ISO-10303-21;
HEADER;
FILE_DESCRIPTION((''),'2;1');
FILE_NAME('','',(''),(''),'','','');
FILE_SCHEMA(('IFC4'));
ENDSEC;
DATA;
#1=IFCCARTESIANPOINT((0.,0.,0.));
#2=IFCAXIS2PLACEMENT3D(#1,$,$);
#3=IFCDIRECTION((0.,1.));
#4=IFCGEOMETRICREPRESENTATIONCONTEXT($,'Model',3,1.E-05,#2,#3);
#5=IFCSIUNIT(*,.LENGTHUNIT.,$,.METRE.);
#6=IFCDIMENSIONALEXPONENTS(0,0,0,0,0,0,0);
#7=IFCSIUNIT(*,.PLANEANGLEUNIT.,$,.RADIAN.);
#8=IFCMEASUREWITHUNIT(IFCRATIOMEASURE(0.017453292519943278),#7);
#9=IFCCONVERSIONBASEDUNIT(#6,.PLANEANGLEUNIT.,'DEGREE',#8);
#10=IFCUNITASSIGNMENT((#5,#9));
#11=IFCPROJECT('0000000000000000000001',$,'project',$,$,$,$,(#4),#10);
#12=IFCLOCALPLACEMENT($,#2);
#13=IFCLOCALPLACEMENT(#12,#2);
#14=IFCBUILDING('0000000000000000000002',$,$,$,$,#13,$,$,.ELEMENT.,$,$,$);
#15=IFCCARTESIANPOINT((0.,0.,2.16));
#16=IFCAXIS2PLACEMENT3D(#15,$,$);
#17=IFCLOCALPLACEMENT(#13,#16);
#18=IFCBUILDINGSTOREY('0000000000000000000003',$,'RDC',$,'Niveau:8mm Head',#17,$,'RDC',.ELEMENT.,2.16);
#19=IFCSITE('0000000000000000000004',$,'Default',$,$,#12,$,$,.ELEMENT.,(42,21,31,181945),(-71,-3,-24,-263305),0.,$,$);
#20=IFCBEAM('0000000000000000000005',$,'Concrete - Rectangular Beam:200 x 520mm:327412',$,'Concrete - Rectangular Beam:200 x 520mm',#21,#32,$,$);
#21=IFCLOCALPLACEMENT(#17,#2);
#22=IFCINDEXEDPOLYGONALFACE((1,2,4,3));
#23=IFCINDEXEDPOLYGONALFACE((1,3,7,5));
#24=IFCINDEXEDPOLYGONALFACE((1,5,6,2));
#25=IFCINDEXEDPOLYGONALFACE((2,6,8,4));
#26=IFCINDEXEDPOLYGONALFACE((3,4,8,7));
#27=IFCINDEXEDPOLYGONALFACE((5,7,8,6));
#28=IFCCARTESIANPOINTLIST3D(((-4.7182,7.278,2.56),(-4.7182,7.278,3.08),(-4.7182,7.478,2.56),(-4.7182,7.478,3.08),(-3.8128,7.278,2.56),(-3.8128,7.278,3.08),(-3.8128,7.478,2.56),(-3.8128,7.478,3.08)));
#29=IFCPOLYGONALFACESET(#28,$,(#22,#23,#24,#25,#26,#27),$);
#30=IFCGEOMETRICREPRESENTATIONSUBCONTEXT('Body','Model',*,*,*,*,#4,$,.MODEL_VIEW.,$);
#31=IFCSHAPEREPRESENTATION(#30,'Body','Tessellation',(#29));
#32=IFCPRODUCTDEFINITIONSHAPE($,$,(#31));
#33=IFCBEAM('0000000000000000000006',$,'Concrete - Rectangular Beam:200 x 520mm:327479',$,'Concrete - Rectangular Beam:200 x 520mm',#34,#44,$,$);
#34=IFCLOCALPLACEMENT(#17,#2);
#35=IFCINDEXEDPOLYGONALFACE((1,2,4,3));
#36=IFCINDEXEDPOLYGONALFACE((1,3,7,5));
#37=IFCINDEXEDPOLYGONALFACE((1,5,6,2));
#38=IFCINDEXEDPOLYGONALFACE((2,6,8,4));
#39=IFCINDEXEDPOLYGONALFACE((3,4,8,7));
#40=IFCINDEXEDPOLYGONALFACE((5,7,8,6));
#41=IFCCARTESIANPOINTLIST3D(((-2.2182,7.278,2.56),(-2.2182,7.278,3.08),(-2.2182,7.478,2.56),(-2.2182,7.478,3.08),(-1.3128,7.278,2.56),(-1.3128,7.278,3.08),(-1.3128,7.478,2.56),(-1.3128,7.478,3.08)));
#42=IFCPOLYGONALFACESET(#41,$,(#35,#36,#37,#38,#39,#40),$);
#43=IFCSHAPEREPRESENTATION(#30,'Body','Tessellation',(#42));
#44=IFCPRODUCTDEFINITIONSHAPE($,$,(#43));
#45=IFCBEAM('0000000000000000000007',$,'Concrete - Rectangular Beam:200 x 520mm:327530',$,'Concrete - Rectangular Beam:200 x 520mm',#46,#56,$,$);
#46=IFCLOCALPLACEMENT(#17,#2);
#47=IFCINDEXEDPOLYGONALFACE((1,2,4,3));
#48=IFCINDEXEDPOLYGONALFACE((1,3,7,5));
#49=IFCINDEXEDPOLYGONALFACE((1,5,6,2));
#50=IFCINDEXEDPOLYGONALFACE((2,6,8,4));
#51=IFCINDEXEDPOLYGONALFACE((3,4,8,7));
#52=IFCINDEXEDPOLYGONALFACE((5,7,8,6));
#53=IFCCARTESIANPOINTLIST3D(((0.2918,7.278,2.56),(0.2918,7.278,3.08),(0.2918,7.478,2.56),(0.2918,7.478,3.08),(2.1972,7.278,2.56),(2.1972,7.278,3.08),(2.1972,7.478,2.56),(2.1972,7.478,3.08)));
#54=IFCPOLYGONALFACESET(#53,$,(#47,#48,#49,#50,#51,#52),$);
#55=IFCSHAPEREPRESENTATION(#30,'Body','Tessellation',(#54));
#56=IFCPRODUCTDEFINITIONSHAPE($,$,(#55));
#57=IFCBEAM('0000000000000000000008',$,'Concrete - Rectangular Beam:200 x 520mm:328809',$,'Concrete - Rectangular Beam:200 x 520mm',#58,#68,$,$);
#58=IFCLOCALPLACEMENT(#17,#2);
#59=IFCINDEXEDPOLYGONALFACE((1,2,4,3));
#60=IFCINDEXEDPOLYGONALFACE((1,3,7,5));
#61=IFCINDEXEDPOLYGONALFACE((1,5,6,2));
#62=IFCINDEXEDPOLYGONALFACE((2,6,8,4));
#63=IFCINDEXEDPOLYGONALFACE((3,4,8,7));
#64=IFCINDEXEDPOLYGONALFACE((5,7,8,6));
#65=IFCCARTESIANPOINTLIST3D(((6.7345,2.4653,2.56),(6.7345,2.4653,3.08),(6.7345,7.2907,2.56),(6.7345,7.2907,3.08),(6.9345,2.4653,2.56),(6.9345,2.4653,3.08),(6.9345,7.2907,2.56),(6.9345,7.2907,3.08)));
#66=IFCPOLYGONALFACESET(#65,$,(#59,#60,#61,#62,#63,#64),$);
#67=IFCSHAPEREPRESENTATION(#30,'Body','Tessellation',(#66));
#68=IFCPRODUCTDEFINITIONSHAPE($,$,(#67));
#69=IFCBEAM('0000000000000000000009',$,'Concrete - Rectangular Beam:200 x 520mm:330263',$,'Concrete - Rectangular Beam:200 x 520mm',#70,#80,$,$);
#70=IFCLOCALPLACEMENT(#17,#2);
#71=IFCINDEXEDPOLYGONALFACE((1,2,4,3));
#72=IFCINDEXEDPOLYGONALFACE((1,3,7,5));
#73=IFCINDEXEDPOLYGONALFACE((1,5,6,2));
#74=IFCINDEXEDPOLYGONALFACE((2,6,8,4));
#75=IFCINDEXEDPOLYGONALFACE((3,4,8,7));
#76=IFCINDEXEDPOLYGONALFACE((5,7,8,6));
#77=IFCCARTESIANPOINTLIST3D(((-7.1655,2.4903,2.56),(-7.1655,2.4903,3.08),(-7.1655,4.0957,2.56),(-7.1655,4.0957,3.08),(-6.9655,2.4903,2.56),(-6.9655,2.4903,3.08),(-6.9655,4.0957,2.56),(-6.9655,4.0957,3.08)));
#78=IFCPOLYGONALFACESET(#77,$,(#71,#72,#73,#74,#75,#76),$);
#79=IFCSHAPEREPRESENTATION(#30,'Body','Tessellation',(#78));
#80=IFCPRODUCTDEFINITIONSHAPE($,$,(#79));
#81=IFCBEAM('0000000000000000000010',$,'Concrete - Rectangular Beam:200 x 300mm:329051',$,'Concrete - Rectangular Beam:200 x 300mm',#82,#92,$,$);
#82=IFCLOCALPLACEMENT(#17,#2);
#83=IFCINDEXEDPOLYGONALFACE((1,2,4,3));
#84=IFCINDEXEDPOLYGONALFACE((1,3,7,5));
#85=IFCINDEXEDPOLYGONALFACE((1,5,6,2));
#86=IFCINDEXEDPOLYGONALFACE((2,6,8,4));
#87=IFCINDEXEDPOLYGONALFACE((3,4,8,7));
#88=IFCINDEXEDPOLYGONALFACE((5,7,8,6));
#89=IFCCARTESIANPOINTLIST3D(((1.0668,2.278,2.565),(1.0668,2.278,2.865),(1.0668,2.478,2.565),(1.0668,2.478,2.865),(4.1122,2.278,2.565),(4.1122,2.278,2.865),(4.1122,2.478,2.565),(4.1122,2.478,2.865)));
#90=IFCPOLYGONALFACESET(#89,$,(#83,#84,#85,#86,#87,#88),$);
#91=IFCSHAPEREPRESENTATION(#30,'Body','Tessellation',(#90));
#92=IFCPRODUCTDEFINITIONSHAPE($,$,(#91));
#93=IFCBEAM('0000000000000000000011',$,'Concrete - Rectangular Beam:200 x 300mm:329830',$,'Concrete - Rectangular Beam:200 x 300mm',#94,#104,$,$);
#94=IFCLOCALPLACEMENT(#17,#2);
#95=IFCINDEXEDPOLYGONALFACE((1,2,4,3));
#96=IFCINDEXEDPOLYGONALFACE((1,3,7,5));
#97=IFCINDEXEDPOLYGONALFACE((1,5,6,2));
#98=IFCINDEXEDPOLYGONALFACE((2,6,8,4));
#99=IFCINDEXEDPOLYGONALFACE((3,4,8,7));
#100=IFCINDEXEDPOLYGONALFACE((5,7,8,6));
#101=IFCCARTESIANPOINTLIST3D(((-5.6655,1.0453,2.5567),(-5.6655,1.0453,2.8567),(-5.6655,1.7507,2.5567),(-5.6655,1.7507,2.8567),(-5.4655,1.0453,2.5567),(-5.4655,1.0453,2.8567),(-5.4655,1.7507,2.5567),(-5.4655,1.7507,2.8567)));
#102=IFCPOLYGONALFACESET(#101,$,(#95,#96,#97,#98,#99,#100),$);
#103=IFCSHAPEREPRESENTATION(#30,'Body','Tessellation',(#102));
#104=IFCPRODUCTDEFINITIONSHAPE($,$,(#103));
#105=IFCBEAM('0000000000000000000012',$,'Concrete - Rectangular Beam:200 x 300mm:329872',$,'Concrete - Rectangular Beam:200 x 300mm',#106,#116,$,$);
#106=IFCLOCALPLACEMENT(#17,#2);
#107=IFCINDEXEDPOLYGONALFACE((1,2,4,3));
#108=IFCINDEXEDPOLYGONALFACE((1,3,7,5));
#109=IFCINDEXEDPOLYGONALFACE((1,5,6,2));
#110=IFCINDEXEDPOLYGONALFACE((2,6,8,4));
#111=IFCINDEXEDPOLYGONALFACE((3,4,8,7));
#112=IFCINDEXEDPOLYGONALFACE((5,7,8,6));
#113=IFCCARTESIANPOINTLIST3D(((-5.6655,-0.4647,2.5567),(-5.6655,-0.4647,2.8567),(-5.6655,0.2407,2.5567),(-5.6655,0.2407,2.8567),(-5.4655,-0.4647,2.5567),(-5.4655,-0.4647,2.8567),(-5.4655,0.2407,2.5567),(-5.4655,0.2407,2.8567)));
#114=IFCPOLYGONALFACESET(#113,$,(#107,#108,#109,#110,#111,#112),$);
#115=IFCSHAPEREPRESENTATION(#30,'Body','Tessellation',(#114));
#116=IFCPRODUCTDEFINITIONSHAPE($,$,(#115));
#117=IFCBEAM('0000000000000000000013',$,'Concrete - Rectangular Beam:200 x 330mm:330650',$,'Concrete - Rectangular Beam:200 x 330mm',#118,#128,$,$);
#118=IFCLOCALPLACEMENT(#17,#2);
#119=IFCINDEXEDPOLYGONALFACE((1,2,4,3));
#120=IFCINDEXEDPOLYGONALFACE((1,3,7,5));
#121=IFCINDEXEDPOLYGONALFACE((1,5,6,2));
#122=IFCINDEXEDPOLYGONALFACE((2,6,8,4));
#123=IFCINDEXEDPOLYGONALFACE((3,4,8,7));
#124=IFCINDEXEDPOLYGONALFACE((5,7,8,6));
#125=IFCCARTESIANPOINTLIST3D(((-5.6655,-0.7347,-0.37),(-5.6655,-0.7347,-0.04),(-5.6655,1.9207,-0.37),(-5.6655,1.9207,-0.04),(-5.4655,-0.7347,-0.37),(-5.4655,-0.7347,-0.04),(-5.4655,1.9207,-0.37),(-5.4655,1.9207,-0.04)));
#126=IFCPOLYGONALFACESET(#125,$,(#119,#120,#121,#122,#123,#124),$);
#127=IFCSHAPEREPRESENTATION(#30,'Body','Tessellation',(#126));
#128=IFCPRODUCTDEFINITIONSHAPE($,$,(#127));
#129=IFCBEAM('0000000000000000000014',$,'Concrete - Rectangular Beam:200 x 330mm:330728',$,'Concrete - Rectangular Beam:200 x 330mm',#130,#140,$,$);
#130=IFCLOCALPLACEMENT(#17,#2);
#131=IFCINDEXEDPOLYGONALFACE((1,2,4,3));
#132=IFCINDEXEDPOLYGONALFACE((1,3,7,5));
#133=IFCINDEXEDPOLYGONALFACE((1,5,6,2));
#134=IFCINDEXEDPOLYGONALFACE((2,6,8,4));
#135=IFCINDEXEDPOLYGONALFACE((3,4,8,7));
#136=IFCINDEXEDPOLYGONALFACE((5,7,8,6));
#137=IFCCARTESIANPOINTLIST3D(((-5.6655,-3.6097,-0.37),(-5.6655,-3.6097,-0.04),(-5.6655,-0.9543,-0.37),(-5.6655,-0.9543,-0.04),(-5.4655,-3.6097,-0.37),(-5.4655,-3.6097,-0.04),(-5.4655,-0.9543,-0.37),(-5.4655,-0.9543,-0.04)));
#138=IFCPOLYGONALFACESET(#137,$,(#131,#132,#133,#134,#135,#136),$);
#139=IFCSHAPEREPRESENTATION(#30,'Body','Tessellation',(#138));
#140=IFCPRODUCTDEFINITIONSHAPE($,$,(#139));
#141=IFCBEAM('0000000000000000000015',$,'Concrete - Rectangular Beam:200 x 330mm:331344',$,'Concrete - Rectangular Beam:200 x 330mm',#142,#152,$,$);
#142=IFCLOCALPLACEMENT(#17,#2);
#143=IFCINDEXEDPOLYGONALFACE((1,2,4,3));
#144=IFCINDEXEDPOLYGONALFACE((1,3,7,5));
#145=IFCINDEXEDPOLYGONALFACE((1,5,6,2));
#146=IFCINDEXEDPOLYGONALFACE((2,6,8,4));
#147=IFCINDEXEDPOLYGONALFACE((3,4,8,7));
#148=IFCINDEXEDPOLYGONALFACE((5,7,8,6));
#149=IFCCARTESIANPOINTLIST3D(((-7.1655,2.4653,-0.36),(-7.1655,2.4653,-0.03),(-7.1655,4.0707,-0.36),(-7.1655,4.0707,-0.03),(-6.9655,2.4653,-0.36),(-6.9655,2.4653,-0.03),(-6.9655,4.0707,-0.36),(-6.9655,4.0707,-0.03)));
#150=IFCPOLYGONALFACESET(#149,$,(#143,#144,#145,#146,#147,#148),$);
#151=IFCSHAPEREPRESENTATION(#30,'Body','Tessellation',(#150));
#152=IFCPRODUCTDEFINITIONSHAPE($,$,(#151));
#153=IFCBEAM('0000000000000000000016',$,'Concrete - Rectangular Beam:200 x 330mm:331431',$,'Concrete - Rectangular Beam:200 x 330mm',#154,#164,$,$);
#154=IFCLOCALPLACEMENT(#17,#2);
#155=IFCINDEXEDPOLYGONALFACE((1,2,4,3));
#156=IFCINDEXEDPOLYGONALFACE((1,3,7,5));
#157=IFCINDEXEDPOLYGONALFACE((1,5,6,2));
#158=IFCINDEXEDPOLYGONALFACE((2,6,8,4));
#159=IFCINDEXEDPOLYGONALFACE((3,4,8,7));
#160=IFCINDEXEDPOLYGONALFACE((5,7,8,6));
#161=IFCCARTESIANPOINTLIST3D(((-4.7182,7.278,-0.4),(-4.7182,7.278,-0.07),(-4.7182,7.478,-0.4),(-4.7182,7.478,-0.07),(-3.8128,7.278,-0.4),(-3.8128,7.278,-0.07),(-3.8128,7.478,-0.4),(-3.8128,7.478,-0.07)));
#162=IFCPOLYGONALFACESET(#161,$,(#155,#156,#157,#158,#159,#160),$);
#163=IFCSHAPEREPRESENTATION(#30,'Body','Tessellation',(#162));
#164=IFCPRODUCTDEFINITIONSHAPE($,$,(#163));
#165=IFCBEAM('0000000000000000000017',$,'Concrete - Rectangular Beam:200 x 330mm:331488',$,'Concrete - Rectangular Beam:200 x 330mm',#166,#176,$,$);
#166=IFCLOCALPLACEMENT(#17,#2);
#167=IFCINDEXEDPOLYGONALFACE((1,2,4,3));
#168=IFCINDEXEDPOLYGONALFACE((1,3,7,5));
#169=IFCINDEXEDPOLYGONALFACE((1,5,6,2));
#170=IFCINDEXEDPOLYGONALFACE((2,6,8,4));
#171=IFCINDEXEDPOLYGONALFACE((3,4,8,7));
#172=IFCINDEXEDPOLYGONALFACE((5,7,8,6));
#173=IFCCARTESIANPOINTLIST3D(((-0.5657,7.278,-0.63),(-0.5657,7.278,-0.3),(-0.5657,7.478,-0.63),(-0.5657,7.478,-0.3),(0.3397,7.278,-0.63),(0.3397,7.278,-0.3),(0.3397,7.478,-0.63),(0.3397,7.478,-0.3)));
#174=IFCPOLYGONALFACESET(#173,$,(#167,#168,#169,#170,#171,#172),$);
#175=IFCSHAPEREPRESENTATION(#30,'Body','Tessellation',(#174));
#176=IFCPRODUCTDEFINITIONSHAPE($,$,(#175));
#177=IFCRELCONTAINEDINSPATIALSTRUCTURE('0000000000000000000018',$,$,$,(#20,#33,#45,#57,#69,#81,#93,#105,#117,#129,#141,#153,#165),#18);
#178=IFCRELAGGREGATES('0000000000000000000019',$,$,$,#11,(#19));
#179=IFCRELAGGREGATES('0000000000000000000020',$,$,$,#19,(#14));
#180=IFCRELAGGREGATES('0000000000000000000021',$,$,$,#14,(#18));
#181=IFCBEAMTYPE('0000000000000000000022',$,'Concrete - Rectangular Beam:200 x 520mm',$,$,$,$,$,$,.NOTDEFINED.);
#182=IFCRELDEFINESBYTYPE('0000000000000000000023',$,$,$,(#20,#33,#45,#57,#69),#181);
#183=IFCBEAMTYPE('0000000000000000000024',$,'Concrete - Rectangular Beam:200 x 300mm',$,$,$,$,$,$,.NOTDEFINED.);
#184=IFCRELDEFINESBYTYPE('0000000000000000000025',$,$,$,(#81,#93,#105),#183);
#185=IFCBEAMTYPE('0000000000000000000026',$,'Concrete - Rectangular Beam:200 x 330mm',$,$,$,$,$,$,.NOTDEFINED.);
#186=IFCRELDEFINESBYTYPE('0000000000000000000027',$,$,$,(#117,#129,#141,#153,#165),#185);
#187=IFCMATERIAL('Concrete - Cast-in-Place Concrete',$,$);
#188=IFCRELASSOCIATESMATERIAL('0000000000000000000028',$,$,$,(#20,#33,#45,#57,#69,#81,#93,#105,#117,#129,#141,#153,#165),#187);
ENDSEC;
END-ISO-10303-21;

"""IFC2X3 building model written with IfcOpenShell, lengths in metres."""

from ifc_helpers import new_model, entity, si_unit, converted_unit, direction, frame, frame_2d, origin, place, context, subcontext, project, spatial, rectangle, extrude, material, type_object, element, save


model = new_model("IFC2X3")

# Units and contexts
model_context = context("Model", 3, precision=1e-05, world=origin(), true_north=direction((0.0, 1.0)))
body_context = subcontext(model_context, "Body", "Model", "MODEL_VIEW")
ifc_project = project(units=[si_unit("LENGTHUNIT", "METRE"), converted_unit("PLANEANGLEUNIT", "DEGREE", entity("IfcRatioMeasure", 0.017453292519943278), si_unit("PLANEANGLEUNIT", "RADIAN"), dimensions=[0, 0, 0, 0, 0, 0, 0])], contexts=[model_context])

# Site, building, storey
site_placement = place(None, origin())
site = spatial("IfcSite", under=ifc_project, at=site_placement, Name="Default", CompositionType="ELEMENT", RefLatitude=(42, 21, 31, 181945), RefLongitude=(-71, -3, -24, -263305), RefElevation=0.0)
building_placement = place(site_placement, origin())
building = spatial("IfcBuilding", under=site, at=building_placement, CompositionType="ELEMENT")
storey_placement = place(building_placement, frame((0.0, 0.0, 2.16)))
storey = spatial("IfcBuildingStorey", under=building, at=storey_placement, Name="RDC", ObjectType="Niveau:8mm Head", LongName="RDC", CompositionType="ELEMENT", Elevation=2.16)

# Beams
ifc_material_1 = material(Name="Concrete - Cast-in-Place Concrete")
beam_type_1 = type_object("IfcBeamType", Name="Concrete - Rectangular Beam:200 x 520mm", PredefinedType="NOTDEFINED")
beam_1_placement = place(storey_placement, frame((-4.7055, 7.378, 3.08)))
element("IfcBeam", 1, at=beam_1_placement, inside=storey, type_object=beam_type_1, material=ifc_material_1, Name="Concrete - Rectangular Beam:200 x 520mm:327412", ObjectType="Concrete - Rectangular Beam:200 x 520mm", context=body_context, shape_type="SweptSolid", body=[
    extrude(rectangle(XDim=0.52, YDim=0.2, at=frame_2d((0.0, 0.0), x_axis=(1.0, 0.0))), frame((-0.0127, 0.0, -0.26), z_axis=(1.0, 0.0, 0.0), x_axis=(0.0, 0.0, -1.0)), (0.0, 0.0, 1.0), 0.9054),
])
beam_2_placement = place(storey_placement, frame((-2.2055, 7.378, 3.08)))
element("IfcBeam", 2, at=beam_2_placement, inside=storey, type_object=beam_type_1, material=ifc_material_1, Name="Concrete - Rectangular Beam:200 x 520mm:327479", ObjectType="Concrete - Rectangular Beam:200 x 520mm", context=body_context, shape_type="SweptSolid", body=[
    extrude(rectangle(XDim=0.52, YDim=0.2, at=frame_2d((0.0, 0.0), x_axis=(1.0, 0.0))), frame((-0.0127, 0.0, -0.26), z_axis=(1.0, 0.0, 0.0), x_axis=(0.0, 0.0, -1.0)), (0.0, 0.0, 1.0), 0.9054),
])
beam_3_placement = place(storey_placement, frame((0.3045, 7.378, 3.08)))
element("IfcBeam", 3, at=beam_3_placement, inside=storey, type_object=beam_type_1, material=ifc_material_1, Name="Concrete - Rectangular Beam:200 x 520mm:327530", ObjectType="Concrete - Rectangular Beam:200 x 520mm", context=body_context, shape_type="SweptSolid", body=[
    extrude(rectangle(XDim=0.52, YDim=0.2, at=frame_2d((0.0, 0.0), x_axis=(1.0, 0.0))), frame((-0.0127, 0.0, -0.26), z_axis=(1.0, 0.0, 0.0), x_axis=(0.0, 0.0, -1.0)), (0.0, 0.0, 1.0), 1.9054),
])
beam_4_placement = place(storey_placement, frame((6.8345, 7.278, 3.08), z_axis=(0.0, 0.0, 1.0), x_axis=(0.0, -1.0, 0.0)))
element("IfcBeam", 4, at=beam_4_placement, inside=storey, type_object=beam_type_1, material=ifc_material_1, Name="Concrete - Rectangular Beam:200 x 520mm:328809", ObjectType="Concrete - Rectangular Beam:200 x 520mm", context=body_context, shape_type="SweptSolid", body=[
    extrude(rectangle(XDim=0.52, YDim=0.2, at=frame_2d((0.0, 0.0), x_axis=(1.0, 0.0))), frame((-0.0127, 0.0, -0.26), z_axis=(1.0, 0.0, 0.0), x_axis=(0.0, 0.0, -1.0)), (0.0, 0.0, 1.0), 4.8254),
])
beam_5_placement = place(storey_placement, frame((-7.0655, 2.503, 3.08), z_axis=(0.0, 0.0, 1.0), x_axis=(0.0, 1.0, 0.0)))
element("IfcBeam", 5, at=beam_5_placement, inside=storey, type_object=beam_type_1, material=ifc_material_1, Name="Concrete - Rectangular Beam:200 x 520mm:330263", ObjectType="Concrete - Rectangular Beam:200 x 520mm", context=body_context, shape_type="SweptSolid", body=[
    extrude(rectangle(XDim=0.52, YDim=0.2, at=frame_2d((0.0, 0.0), x_axis=(1.0, 0.0))), frame((-0.0127, 0.0, -0.26), z_axis=(1.0, 0.0, 0.0), x_axis=(0.0, 0.0, -1.0)), (0.0, 0.0, 1.0), 1.6054),
])
beam_type_2 = type_object("IfcBeamType", Name="Concrete - Rectangular Beam:200 x 300mm", PredefinedType="NOTDEFINED")
beam_6_placement = place(storey_placement, frame((1.0795, 2.378, 2.865)))
element("IfcBeam", 6, at=beam_6_placement, inside=storey, type_object=beam_type_2, material=ifc_material_1, Name="Concrete - Rectangular Beam:200 x 300mm:329051", ObjectType="Concrete - Rectangular Beam:200 x 300mm", context=body_context, shape_type="SweptSolid", body=[
    extrude(rectangle(XDim=0.3, YDim=0.2, at=frame_2d((0.0, 0.0), x_axis=(1.0, 0.0))), frame((-0.0127, 0.0, -0.15), z_axis=(1.0, 0.0, 0.0), x_axis=(0.0, 0.0, -1.0)), (0.0, 0.0, 1.0), 3.0454),
])
beam_7_placement = place(storey_placement, frame((-5.5655, 1.738, 2.8567), z_axis=(0.0, 0.0, 1.0), x_axis=(0.0, -1.0, 0.0)))
element("IfcBeam", 7, at=beam_7_placement, inside=storey, type_object=beam_type_2, material=ifc_material_1, Name="Concrete - Rectangular Beam:200 x 300mm:329830", ObjectType="Concrete - Rectangular Beam:200 x 300mm", context=body_context, shape_type="SweptSolid", body=[
    extrude(rectangle(XDim=0.3, YDim=0.2, at=frame_2d((0.0, 0.0), x_axis=(1.0, 0.0))), frame((-0.0127, 0.0, -0.15), z_axis=(1.0, 0.0, 0.0), x_axis=(0.0, 0.0, -1.0)), (0.0, 0.0, 1.0), 0.7054),
])
beam_8_placement = place(storey_placement, frame((-5.5655, 0.228, 2.8567), z_axis=(0.0, 0.0, 1.0), x_axis=(0.0, -1.0, 0.0)))
element("IfcBeam", 8, at=beam_8_placement, inside=storey, type_object=beam_type_2, material=ifc_material_1, Name="Concrete - Rectangular Beam:200 x 300mm:329872", ObjectType="Concrete - Rectangular Beam:200 x 300mm", context=body_context, shape_type="SweptSolid", body=[
    extrude(rectangle(XDim=0.3, YDim=0.2, at=frame_2d((0.0, 0.0), x_axis=(1.0, 0.0))), frame((-0.0127, 0.0, -0.15), z_axis=(1.0, 0.0, 0.0), x_axis=(0.0, 0.0, -1.0)), (0.0, 0.0, 1.0), 0.7054),
])
beam_type_3 = type_object("IfcBeamType", Name="Concrete - Rectangular Beam:200 x 330mm", PredefinedType="NOTDEFINED")
beam_9_placement = place(storey_placement, frame((-5.5655, 1.908, -0.04), z_axis=(0.0, 0.0, 1.0), x_axis=(0.0, -1.0, 0.0)))
element("IfcBeam", 9, at=beam_9_placement, inside=storey, type_object=beam_type_3, material=ifc_material_1, Name="Concrete - Rectangular Beam:200 x 330mm:330650", ObjectType="Concrete - Rectangular Beam:200 x 330mm", context=body_context, shape_type="SweptSolid", body=[
    extrude(rectangle(XDim=0.33, YDim=0.2, at=frame_2d((0.0, 0.0), x_axis=(1.0, 0.0))), frame((-0.0127, 0.0, -0.165), z_axis=(1.0, 0.0, 0.0), x_axis=(0.0, 0.0, -1.0)), (0.0, 0.0, 1.0), 2.6554),
])
beam_10_placement = place(storey_placement, frame((-5.5655, -3.597, -0.04), z_axis=(0.0, 0.0, 1.0), x_axis=(0.0, 1.0, 0.0)))
element("IfcBeam", 10, at=beam_10_placement, inside=storey, type_object=beam_type_3, material=ifc_material_1, Name="Concrete - Rectangular Beam:200 x 330mm:330728", ObjectType="Concrete - Rectangular Beam:200 x 330mm", context=body_context, shape_type="SweptSolid", body=[
    extrude(rectangle(XDim=0.33, YDim=0.2, at=frame_2d((0.0, 0.0), x_axis=(1.0, 0.0))), frame((-0.0127, 0.0, -0.165), z_axis=(1.0, 0.0, 0.0), x_axis=(0.0, 0.0, -1.0)), (0.0, 0.0, 1.0), 2.6554),
])
beam_11_placement = place(storey_placement, frame((-7.0655, 2.478, -0.03), z_axis=(0.0, 0.0, 1.0), x_axis=(0.0, 1.0, 0.0)))
element("IfcBeam", 11, at=beam_11_placement, inside=storey, type_object=beam_type_3, material=ifc_material_1, Name="Concrete - Rectangular Beam:200 x 330mm:331344", ObjectType="Concrete - Rectangular Beam:200 x 330mm", context=body_context, shape_type="SweptSolid", body=[
    extrude(rectangle(XDim=0.33, YDim=0.2, at=frame_2d((0.0, 0.0), x_axis=(1.0, 0.0))), frame((-0.0127, 0.0, -0.165), z_axis=(1.0, 0.0, 0.0), x_axis=(0.0, 0.0, -1.0)), (0.0, 0.0, 1.0), 1.6054),
])
beam_12_placement = place(storey_placement, frame((-4.7055, 7.378, -0.07)))
element("IfcBeam", 12, at=beam_12_placement, inside=storey, type_object=beam_type_3, material=ifc_material_1, Name="Concrete - Rectangular Beam:200 x 330mm:331431", ObjectType="Concrete - Rectangular Beam:200 x 330mm", context=body_context, shape_type="SweptSolid", body=[
    extrude(rectangle(XDim=0.33, YDim=0.2, at=frame_2d((0.0, 0.0), x_axis=(1.0, 0.0))), frame((-0.0127, 0.0, -0.165), z_axis=(1.0, 0.0, 0.0), x_axis=(0.0, 0.0, -1.0)), (0.0, 0.0, 1.0), 0.9054),
])
beam_13_placement = place(storey_placement, frame((-0.553, 7.378, -0.3)))
element("IfcBeam", 13, at=beam_13_placement, inside=storey, type_object=beam_type_3, material=ifc_material_1, Name="Concrete - Rectangular Beam:200 x 330mm:331488", ObjectType="Concrete - Rectangular Beam:200 x 330mm", context=body_context, shape_type="SweptSolid", body=[
    extrude(rectangle(XDim=0.33, YDim=0.2, at=frame_2d((0.0, 0.0), x_axis=(1.0, 0.0))), frame((-0.0127, 0.0, -0.165), z_axis=(1.0, 0.0, 0.0), x_axis=(0.0, 0.0, -1.0)), (0.0, 0.0, 1.0), 0.9054),
])

save(model, "model.ifc")
